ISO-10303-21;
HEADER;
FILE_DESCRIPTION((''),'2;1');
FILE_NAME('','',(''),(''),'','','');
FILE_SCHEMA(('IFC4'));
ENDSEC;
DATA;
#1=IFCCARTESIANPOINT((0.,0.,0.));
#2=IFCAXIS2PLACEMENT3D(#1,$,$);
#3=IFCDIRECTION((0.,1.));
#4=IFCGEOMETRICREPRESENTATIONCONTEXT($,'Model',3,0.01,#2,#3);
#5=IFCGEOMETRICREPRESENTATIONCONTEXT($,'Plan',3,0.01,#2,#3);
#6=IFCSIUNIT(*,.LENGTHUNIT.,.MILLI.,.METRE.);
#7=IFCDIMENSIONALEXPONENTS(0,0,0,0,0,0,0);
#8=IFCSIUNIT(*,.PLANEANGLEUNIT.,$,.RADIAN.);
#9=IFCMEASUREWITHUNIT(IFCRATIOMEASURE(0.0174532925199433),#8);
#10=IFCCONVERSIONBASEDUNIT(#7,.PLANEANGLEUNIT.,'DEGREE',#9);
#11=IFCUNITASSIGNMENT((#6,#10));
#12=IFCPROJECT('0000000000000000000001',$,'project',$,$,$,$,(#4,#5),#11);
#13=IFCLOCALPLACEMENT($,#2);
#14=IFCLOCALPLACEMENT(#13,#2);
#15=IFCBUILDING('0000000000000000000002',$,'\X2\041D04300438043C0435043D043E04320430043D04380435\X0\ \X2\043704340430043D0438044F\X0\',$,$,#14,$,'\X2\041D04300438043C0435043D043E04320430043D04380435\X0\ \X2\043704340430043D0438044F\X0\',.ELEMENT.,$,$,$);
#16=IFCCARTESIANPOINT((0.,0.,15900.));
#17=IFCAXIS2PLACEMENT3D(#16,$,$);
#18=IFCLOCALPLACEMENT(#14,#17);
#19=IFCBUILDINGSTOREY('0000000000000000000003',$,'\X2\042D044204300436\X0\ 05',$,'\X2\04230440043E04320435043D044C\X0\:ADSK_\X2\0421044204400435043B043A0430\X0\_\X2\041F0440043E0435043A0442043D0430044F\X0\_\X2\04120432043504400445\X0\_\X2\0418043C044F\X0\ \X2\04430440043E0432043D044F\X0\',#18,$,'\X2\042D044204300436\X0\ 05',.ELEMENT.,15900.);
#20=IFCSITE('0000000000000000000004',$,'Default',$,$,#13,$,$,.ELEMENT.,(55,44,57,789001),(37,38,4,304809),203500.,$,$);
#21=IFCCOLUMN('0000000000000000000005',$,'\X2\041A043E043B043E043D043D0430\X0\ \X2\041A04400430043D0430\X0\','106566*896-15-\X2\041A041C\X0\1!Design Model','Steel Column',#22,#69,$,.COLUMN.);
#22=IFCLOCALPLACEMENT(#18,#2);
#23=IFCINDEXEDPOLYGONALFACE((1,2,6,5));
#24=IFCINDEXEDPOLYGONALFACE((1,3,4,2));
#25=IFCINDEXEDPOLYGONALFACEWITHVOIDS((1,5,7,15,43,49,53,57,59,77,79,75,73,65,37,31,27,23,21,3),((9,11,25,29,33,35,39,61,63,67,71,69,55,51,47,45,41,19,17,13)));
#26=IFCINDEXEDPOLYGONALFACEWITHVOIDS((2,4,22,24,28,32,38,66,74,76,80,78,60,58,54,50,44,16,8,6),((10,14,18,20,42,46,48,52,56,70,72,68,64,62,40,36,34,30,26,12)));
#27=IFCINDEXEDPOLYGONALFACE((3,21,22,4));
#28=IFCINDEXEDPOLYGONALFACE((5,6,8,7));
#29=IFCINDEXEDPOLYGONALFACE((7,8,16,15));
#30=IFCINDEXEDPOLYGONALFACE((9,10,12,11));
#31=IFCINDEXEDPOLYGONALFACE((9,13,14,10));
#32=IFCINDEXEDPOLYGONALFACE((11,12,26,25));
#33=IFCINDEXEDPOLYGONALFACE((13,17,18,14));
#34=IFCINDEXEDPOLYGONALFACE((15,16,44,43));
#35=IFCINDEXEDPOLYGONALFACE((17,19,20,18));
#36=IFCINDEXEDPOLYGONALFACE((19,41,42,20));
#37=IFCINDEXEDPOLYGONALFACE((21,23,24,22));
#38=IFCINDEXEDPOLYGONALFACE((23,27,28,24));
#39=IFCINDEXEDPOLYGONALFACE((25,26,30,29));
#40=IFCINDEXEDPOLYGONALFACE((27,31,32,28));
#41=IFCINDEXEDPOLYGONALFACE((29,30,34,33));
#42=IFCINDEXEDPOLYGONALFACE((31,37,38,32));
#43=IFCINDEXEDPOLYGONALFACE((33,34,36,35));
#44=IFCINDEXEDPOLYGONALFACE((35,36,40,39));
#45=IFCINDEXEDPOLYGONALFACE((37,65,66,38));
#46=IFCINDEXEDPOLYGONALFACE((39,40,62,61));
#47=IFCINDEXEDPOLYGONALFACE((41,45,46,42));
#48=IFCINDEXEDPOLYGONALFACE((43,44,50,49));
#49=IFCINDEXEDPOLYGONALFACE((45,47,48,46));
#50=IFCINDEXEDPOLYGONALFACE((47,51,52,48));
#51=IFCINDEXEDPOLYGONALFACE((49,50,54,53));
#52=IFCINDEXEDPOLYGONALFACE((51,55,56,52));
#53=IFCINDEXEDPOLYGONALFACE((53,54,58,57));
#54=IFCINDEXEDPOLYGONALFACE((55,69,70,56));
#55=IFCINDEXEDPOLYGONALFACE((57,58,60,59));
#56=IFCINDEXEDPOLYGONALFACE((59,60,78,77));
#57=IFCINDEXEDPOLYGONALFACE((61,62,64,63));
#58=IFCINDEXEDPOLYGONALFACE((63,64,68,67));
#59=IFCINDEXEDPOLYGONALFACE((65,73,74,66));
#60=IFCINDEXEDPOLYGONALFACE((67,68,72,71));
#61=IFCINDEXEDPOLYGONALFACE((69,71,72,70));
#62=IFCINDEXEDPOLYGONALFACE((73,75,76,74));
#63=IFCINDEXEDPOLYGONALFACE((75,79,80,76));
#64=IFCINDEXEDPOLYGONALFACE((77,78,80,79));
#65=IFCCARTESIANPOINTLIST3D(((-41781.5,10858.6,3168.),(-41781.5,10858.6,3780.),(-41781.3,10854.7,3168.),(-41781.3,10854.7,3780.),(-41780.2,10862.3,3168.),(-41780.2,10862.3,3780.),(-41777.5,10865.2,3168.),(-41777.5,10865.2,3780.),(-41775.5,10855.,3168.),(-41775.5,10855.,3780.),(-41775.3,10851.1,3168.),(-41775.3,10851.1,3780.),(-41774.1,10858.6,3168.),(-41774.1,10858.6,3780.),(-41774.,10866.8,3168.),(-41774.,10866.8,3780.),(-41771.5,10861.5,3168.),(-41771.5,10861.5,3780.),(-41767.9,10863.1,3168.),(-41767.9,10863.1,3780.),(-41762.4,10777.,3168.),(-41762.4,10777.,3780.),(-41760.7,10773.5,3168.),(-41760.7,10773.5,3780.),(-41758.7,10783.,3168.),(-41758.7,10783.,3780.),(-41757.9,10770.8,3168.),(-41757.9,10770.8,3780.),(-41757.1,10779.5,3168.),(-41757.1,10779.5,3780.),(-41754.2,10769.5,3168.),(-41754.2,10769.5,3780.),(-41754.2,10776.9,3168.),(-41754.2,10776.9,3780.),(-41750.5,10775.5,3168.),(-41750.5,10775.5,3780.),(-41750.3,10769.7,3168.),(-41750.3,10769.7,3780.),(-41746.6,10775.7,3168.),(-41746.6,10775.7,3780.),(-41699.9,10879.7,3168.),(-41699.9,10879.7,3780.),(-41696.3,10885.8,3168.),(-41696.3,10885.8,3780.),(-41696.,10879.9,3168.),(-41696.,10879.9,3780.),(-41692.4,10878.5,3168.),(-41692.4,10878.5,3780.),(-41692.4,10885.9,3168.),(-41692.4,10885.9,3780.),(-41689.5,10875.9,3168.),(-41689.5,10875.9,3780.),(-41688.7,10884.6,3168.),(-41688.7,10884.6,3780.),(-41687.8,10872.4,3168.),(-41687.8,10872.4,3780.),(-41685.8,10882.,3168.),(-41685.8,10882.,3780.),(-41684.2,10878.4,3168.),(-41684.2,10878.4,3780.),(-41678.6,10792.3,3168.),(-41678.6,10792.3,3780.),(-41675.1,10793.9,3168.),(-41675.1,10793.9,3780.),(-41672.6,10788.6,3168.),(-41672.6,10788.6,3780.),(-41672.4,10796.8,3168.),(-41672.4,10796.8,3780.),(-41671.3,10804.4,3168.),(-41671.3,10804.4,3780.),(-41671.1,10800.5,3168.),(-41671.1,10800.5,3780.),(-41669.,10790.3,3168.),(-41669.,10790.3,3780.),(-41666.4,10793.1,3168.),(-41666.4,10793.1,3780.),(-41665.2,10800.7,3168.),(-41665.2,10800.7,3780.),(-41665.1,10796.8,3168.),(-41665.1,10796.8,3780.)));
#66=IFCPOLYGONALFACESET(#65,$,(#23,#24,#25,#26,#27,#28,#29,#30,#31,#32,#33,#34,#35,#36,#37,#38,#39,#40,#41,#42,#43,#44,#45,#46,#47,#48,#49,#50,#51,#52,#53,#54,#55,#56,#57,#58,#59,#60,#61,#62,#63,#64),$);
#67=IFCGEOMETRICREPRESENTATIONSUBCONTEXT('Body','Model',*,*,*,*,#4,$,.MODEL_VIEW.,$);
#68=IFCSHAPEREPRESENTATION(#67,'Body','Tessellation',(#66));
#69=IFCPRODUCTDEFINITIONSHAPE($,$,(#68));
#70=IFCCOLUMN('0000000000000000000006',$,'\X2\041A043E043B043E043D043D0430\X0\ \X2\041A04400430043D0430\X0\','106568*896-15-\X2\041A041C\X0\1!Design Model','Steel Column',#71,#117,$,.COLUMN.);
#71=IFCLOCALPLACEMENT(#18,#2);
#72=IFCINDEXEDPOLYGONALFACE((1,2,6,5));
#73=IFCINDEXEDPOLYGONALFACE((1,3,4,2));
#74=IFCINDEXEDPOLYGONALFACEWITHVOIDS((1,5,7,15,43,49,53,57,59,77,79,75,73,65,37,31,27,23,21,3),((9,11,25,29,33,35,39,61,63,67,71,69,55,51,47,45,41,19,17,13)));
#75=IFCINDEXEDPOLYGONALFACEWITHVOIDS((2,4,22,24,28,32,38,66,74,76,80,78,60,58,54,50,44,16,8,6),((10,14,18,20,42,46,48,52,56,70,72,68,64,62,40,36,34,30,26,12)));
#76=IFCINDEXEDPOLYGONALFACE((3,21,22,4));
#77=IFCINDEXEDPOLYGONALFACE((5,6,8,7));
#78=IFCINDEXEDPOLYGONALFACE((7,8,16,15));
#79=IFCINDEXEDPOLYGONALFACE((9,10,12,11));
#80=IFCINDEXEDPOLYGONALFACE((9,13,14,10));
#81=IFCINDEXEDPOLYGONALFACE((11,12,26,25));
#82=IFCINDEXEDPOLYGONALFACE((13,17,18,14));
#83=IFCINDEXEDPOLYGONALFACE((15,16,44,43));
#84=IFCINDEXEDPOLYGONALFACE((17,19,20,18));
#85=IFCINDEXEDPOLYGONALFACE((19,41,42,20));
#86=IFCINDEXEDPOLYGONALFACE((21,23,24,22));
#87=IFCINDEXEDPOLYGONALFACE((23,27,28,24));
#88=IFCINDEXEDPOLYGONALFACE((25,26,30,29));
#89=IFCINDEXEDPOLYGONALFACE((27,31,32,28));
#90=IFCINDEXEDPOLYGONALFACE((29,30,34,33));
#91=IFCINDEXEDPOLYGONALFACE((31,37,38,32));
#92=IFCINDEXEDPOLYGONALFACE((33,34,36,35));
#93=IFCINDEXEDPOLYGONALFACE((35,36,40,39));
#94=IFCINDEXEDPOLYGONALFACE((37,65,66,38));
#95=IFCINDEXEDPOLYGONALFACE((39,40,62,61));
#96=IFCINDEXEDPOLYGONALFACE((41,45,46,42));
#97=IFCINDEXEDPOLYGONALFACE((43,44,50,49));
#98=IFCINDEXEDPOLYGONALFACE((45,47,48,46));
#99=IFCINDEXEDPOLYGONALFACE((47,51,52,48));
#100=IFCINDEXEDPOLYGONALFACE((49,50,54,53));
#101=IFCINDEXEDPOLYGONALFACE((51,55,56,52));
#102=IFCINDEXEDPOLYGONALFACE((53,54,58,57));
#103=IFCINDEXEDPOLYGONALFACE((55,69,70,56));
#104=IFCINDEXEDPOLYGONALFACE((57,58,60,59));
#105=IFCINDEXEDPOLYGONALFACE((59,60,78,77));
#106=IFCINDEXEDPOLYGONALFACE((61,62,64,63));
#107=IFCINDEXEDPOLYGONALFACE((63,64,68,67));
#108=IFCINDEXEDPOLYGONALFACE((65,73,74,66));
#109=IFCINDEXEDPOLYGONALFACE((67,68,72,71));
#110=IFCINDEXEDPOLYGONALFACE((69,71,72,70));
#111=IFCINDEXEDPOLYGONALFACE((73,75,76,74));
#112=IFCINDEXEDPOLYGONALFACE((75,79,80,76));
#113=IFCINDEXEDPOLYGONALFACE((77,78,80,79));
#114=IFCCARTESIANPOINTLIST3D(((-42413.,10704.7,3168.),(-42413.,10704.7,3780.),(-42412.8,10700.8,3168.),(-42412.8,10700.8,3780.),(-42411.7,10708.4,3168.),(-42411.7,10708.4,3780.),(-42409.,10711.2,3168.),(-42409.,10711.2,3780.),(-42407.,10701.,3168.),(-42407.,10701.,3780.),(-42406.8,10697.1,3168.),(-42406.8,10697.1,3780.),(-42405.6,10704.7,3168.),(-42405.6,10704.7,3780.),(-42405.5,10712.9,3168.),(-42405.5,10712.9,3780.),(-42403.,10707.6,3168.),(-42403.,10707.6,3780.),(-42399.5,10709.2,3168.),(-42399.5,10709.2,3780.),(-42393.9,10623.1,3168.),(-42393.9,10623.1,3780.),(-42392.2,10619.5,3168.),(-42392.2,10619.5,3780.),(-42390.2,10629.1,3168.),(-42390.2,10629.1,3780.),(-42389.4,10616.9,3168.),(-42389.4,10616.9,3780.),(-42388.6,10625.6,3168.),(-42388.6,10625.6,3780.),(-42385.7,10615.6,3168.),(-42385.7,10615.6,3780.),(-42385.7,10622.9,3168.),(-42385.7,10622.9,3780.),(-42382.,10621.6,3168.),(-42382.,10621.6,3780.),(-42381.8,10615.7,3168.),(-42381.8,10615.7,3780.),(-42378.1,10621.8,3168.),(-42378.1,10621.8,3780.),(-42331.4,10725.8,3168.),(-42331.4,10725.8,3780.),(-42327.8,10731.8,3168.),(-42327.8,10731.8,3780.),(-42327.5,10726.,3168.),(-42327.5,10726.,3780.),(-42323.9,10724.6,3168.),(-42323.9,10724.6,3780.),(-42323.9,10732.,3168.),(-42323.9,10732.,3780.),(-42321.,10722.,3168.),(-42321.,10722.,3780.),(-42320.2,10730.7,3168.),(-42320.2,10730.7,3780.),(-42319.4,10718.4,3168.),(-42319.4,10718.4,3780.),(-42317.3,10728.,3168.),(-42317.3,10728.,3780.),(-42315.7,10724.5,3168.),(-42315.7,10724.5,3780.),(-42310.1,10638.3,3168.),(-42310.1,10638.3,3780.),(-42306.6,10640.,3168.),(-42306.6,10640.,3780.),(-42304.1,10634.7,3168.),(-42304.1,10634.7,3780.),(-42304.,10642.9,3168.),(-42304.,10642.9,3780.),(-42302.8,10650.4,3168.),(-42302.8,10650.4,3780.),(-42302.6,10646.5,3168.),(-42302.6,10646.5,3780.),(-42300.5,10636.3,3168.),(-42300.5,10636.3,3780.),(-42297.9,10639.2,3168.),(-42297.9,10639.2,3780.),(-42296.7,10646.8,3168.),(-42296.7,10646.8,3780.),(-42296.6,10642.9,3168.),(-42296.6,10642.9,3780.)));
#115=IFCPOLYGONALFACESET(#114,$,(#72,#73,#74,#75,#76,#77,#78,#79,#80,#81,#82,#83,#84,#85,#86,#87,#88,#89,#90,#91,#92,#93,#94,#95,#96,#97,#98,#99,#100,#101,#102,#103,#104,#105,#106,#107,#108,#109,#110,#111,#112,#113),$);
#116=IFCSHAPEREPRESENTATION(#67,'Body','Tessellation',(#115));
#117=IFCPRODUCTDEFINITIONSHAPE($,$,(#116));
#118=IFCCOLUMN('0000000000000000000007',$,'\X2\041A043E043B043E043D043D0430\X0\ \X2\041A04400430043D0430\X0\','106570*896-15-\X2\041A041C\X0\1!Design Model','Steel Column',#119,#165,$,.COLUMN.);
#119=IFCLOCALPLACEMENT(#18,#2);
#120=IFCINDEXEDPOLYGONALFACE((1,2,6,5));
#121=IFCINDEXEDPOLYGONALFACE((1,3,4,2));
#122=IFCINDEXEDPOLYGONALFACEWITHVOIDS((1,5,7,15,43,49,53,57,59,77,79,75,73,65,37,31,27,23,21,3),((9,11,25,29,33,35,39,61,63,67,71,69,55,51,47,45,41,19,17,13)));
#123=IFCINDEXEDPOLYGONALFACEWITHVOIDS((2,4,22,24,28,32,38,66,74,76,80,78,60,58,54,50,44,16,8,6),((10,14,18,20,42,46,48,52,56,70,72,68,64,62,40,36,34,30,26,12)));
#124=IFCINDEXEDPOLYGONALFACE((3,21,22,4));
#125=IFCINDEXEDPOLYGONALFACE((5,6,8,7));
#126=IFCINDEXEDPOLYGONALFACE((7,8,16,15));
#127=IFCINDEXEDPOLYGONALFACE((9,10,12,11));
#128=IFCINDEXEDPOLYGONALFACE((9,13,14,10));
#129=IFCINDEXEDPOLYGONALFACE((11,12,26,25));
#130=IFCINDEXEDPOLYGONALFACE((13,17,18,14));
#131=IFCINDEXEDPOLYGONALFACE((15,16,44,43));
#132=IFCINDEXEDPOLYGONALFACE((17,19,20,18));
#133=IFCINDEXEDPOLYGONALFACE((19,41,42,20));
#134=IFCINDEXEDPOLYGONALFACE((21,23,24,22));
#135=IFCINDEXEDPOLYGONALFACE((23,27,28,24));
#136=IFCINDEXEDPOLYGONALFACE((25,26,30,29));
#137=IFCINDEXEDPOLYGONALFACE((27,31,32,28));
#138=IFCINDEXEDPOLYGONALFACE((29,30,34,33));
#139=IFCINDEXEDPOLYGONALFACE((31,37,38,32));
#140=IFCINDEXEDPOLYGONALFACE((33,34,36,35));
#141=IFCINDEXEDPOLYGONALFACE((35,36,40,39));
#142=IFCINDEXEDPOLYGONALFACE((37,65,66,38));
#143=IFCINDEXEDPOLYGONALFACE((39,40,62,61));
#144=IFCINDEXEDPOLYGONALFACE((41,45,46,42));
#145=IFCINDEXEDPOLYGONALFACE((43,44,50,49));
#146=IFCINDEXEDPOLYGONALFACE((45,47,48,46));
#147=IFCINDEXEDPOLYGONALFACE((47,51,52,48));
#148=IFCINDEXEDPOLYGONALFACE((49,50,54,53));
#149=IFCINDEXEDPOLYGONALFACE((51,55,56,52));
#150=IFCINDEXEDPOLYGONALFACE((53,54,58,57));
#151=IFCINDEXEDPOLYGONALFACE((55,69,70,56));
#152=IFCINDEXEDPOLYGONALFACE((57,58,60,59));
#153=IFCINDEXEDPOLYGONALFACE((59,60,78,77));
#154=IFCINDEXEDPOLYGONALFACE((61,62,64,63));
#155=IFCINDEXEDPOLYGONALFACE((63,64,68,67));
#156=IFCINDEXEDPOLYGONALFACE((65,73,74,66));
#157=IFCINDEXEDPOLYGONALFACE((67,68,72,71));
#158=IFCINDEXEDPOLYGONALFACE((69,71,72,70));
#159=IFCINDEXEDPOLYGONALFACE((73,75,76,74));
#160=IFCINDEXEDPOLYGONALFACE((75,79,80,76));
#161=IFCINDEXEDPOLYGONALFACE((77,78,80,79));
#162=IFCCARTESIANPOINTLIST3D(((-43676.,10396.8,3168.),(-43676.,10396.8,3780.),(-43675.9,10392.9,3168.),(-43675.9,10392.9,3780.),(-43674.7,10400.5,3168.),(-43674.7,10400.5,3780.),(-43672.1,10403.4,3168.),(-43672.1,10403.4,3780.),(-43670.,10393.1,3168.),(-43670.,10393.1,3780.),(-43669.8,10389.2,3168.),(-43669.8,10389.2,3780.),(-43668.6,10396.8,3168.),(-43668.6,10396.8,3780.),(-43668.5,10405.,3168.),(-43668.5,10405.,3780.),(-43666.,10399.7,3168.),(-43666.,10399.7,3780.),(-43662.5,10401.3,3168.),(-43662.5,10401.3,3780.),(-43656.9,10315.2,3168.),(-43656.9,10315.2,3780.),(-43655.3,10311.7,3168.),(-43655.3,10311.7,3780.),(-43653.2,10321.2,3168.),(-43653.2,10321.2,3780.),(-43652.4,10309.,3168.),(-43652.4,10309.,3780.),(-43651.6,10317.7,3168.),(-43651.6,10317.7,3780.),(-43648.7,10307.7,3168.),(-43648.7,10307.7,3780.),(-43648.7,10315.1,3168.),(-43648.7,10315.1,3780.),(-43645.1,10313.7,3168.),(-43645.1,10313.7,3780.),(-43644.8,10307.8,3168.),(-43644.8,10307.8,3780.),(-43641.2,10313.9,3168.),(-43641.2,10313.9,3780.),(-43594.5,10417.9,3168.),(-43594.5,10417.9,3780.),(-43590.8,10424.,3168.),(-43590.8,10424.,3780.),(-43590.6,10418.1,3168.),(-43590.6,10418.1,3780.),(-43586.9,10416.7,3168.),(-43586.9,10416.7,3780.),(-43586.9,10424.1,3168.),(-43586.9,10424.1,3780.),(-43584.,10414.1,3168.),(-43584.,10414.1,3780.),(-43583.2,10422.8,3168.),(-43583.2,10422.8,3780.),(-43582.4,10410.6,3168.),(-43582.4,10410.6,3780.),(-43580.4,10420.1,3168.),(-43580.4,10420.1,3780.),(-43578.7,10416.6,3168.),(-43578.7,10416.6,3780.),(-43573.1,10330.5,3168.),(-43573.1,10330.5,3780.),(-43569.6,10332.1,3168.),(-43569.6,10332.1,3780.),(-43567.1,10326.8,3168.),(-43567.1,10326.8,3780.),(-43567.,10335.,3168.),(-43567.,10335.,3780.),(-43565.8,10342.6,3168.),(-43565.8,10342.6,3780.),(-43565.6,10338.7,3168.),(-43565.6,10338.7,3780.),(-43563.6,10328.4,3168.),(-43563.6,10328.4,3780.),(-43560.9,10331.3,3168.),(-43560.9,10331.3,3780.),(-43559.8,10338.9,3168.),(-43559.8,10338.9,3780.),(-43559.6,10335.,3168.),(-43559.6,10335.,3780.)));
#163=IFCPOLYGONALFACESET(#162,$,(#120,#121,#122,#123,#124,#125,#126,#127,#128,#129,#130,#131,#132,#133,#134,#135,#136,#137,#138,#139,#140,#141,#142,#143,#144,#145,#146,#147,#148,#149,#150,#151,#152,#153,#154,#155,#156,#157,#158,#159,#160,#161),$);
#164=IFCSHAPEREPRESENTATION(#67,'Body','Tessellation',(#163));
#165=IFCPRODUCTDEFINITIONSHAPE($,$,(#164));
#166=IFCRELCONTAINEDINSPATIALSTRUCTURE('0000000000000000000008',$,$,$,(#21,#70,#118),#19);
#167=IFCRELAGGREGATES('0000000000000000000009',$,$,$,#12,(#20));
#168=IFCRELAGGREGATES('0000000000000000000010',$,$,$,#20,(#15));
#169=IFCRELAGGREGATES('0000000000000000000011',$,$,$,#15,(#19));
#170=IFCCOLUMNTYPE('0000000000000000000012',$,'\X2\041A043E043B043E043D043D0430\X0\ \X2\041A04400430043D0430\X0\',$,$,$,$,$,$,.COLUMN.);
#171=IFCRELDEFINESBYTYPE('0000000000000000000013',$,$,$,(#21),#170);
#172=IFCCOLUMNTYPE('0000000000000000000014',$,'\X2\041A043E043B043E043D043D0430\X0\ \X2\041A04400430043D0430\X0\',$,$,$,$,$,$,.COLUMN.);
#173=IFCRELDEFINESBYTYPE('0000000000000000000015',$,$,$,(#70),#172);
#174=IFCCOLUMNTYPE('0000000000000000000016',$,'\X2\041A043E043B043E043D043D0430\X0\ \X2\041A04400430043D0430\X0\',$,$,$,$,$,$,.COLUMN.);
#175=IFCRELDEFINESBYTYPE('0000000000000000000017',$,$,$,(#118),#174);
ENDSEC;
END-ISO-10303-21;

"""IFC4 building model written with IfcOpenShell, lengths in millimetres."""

from ifc_helpers import new_model, entity, si_unit, converted_unit, direction, frame, origin, place, context, subcontext, project, spatial, indexed_curve, outline, extrude, type_object, element, save


model = new_model("IFC4")

# Units and contexts
model_context = context("Model", 3, precision=0.01, world=origin(), true_north=direction((0.0, 1.0)))
plan_context = context("Plan", 3, precision=0.01, world=origin(), true_north=direction((0.0, 1.0)))
body_context = subcontext(model_context, "Body", "Model", "MODEL_VIEW")
ifc_project = project(units=[si_unit("LENGTHUNIT", "METRE", prefix="MILLI"), converted_unit("PLANEANGLEUNIT", "DEGREE", entity("IfcRatioMeasure", 0.0174532925199433), si_unit("PLANEANGLEUNIT", "RADIAN"), dimensions=[0, 0, 0, 0, 0, 0, 0])], contexts=[model_context, plan_context])

# Site, building, storey
site_placement = place(None, origin())
site = spatial("IfcSite", under=ifc_project, at=site_placement, Name="Default", CompositionType="ELEMENT", RefLatitude=(55, 44, 57, 789001), RefLongitude=(37, 38, 4, 304809), RefElevation=203500.0)
building_placement = place(site_placement, origin())
building = spatial("IfcBuilding", under=site, at=building_placement, Name="Наименование здания", LongName="Наименование здания", CompositionType="ELEMENT")
storey_placement = place(building_placement, frame((0.0, 0.0, 15900.0)))
storey = spatial("IfcBuildingStorey", under=building, at=storey_placement, Name="Этаж 05", ObjectType="Уровень:ADSK_Стрелка_Проектная_Вверх_Имя уровня", LongName="Этаж 05", CompositionType="ELEMENT", Elevation=15900.0)

# Columns
placement = place(storey_placement, origin())
column_type_1 = type_object("IfcColumnType", Name="Колонна Крана", PredefinedType="COLUMN")
element("IfcColumn", 1, at=placement, inside=storey, type_object=column_type_1, Name="Колонна Крана", Description="106566*896-15-КМ1!Design Model", ObjectType="Steel Column", PredefinedType="COLUMN", context=body_context, shape_type="SweptSolid", body=[
    extrude(outline(indexed_curve([(29.5, -56.8), (33.4, -56.8), (37.0, -55.3), (39.7, -52.6), (41.2, -49.0), (56.8, 29.5), (56.8, 33.4), (55.3, 37.0), (52.6, 39.7), (49.0, 41.2), (-29.5, 56.8), (-33.4, 56.8), (-37.0, 55.3), (-39.7, 52.6), (-41.2, 49.0), (-56.8, -29.5), (-56.8, -33.4), (-55.3, -37.0), (-52.6, -39.7), (-49.0, -41.2), (29.5, -56.8)], self_intersect=False), holes=[indexed_curve([(-43.1, -37.3), (-46.7, -35.8), (-49.5, -33.1), (-51.0, -29.5), (-51.0, -25.5), (-37.3, 43.1), (-35.8, 46.7), (-33.1, 49.5), (-29.5, 51.0), (-25.5, 51.0), (43.1, 37.3), (46.7, 35.8), (49.5, 33.1), (51.0, 29.5), (51.0, 25.5), (37.3, -43.1), (35.8, -46.7), (33.1, -49.5), (29.5, -51.0), (25.5, -51.0), (-43.1, -37.3)], self_intersect=False)]), frame((-41723.3, 10827.7, 3168.0), z_axis=(0.0, 0.0, 1.0), x_axis=(0.906681, 0.421816, 0.0)), (0.0, 0.0, 1.0), 612.0),
])
column_type_2 = type_object("IfcColumnType", Name="Колонна Крана", PredefinedType="COLUMN")
element("IfcColumn", 2, at=placement, inside=storey, type_object=column_type_2, Name="Колонна Крана", Description="106568*896-15-КМ1!Design Model", ObjectType="Steel Column", PredefinedType="COLUMN", context=body_context, shape_type="SweptSolid", body=[
    extrude(outline(indexed_curve([(29.5, -56.8), (33.4, -56.8), (37.0, -55.3), (39.7, -52.6), (41.2, -49.0), (56.8, 29.5), (56.8, 33.4), (55.3, 37.0), (52.6, 39.7), (49.0, 41.2), (-29.5, 56.8), (-33.4, 56.8), (-37.0, 55.3), (-39.7, 52.6), (-41.2, 49.0), (-56.8, -29.5), (-56.8, -33.4), (-55.3, -37.0), (-52.6, -39.7), (-49.0, -41.2), (29.5, -56.8)], self_intersect=False), holes=[indexed_curve([(-43.1, -37.3), (-46.7, -35.8), (-49.5, -33.1), (-51.0, -29.5), (-51.0, -25.5), (-37.3, 43.1), (-35.8, 46.7), (-33.1, 49.5), (-29.5, 51.0), (-25.5, 51.0), (43.1, 37.3), (46.7, 35.8), (49.5, 33.1), (51.0, 29.5), (51.0, 25.5), (37.3, -43.1), (35.8, -46.7), (33.1, -49.5), (29.5, -51.0), (25.5, -51.0), (-43.1, -37.3)], self_intersect=False)]), frame((-42354.8, 10673.8, 3168.0), z_axis=(0.0, 0.0, 1.0), x_axis=(0.906681, 0.421816, 0.0)), (0.0, 0.0, 1.0), 612.0),
])
column_type_3 = type_object("IfcColumnType", Name="Колонна Крана", PredefinedType="COLUMN")
element("IfcColumn", 3, at=placement, inside=storey, type_object=column_type_3, Name="Колонна Крана", Description="106570*896-15-КМ1!Design Model", ObjectType="Steel Column", PredefinedType="COLUMN", context=body_context, shape_type="SweptSolid", body=[
    extrude(outline(indexed_curve([(29.5, -56.8), (33.4, -56.8), (37.0, -55.3), (39.7, -52.6), (41.2, -49.0), (56.8, 29.5), (56.8, 33.4), (55.3, 37.0), (52.6, 39.7), (49.0, 41.2), (-29.5, 56.8), (-33.4, 56.8), (-37.0, 55.3), (-39.7, 52.6), (-41.2, 49.0), (-56.8, -29.5), (-56.8, -33.4), (-55.3, -37.0), (-52.6, -39.7), (-49.0, -41.2), (29.5, -56.8)], self_intersect=False), holes=[indexed_curve([(-43.1, -37.3), (-46.7, -35.8), (-49.5, -33.1), (-51.0, -29.5), (-51.0, -25.5), (-37.3, 43.1), (-35.8, 46.7), (-33.1, 49.5), (-29.5, 51.0), (-25.5, 51.0), (43.1, 37.3), (46.7, 35.8), (49.5, 33.1), (51.0, 29.5), (51.0, 25.5), (37.3, -43.1), (35.8, -46.7), (33.1, -49.5), (29.5, -51.0), (25.5, -51.0), (-43.1, -37.3)], self_intersect=False)]), frame((-43617.8, 10365.9, 3168.0), z_axis=(0.0, 0.0, 1.0), x_axis=(0.906681, 0.421816, 0.0)), (0.0, 0.0, 1.0), 612.0),
])

save(model, "model.ifc")
